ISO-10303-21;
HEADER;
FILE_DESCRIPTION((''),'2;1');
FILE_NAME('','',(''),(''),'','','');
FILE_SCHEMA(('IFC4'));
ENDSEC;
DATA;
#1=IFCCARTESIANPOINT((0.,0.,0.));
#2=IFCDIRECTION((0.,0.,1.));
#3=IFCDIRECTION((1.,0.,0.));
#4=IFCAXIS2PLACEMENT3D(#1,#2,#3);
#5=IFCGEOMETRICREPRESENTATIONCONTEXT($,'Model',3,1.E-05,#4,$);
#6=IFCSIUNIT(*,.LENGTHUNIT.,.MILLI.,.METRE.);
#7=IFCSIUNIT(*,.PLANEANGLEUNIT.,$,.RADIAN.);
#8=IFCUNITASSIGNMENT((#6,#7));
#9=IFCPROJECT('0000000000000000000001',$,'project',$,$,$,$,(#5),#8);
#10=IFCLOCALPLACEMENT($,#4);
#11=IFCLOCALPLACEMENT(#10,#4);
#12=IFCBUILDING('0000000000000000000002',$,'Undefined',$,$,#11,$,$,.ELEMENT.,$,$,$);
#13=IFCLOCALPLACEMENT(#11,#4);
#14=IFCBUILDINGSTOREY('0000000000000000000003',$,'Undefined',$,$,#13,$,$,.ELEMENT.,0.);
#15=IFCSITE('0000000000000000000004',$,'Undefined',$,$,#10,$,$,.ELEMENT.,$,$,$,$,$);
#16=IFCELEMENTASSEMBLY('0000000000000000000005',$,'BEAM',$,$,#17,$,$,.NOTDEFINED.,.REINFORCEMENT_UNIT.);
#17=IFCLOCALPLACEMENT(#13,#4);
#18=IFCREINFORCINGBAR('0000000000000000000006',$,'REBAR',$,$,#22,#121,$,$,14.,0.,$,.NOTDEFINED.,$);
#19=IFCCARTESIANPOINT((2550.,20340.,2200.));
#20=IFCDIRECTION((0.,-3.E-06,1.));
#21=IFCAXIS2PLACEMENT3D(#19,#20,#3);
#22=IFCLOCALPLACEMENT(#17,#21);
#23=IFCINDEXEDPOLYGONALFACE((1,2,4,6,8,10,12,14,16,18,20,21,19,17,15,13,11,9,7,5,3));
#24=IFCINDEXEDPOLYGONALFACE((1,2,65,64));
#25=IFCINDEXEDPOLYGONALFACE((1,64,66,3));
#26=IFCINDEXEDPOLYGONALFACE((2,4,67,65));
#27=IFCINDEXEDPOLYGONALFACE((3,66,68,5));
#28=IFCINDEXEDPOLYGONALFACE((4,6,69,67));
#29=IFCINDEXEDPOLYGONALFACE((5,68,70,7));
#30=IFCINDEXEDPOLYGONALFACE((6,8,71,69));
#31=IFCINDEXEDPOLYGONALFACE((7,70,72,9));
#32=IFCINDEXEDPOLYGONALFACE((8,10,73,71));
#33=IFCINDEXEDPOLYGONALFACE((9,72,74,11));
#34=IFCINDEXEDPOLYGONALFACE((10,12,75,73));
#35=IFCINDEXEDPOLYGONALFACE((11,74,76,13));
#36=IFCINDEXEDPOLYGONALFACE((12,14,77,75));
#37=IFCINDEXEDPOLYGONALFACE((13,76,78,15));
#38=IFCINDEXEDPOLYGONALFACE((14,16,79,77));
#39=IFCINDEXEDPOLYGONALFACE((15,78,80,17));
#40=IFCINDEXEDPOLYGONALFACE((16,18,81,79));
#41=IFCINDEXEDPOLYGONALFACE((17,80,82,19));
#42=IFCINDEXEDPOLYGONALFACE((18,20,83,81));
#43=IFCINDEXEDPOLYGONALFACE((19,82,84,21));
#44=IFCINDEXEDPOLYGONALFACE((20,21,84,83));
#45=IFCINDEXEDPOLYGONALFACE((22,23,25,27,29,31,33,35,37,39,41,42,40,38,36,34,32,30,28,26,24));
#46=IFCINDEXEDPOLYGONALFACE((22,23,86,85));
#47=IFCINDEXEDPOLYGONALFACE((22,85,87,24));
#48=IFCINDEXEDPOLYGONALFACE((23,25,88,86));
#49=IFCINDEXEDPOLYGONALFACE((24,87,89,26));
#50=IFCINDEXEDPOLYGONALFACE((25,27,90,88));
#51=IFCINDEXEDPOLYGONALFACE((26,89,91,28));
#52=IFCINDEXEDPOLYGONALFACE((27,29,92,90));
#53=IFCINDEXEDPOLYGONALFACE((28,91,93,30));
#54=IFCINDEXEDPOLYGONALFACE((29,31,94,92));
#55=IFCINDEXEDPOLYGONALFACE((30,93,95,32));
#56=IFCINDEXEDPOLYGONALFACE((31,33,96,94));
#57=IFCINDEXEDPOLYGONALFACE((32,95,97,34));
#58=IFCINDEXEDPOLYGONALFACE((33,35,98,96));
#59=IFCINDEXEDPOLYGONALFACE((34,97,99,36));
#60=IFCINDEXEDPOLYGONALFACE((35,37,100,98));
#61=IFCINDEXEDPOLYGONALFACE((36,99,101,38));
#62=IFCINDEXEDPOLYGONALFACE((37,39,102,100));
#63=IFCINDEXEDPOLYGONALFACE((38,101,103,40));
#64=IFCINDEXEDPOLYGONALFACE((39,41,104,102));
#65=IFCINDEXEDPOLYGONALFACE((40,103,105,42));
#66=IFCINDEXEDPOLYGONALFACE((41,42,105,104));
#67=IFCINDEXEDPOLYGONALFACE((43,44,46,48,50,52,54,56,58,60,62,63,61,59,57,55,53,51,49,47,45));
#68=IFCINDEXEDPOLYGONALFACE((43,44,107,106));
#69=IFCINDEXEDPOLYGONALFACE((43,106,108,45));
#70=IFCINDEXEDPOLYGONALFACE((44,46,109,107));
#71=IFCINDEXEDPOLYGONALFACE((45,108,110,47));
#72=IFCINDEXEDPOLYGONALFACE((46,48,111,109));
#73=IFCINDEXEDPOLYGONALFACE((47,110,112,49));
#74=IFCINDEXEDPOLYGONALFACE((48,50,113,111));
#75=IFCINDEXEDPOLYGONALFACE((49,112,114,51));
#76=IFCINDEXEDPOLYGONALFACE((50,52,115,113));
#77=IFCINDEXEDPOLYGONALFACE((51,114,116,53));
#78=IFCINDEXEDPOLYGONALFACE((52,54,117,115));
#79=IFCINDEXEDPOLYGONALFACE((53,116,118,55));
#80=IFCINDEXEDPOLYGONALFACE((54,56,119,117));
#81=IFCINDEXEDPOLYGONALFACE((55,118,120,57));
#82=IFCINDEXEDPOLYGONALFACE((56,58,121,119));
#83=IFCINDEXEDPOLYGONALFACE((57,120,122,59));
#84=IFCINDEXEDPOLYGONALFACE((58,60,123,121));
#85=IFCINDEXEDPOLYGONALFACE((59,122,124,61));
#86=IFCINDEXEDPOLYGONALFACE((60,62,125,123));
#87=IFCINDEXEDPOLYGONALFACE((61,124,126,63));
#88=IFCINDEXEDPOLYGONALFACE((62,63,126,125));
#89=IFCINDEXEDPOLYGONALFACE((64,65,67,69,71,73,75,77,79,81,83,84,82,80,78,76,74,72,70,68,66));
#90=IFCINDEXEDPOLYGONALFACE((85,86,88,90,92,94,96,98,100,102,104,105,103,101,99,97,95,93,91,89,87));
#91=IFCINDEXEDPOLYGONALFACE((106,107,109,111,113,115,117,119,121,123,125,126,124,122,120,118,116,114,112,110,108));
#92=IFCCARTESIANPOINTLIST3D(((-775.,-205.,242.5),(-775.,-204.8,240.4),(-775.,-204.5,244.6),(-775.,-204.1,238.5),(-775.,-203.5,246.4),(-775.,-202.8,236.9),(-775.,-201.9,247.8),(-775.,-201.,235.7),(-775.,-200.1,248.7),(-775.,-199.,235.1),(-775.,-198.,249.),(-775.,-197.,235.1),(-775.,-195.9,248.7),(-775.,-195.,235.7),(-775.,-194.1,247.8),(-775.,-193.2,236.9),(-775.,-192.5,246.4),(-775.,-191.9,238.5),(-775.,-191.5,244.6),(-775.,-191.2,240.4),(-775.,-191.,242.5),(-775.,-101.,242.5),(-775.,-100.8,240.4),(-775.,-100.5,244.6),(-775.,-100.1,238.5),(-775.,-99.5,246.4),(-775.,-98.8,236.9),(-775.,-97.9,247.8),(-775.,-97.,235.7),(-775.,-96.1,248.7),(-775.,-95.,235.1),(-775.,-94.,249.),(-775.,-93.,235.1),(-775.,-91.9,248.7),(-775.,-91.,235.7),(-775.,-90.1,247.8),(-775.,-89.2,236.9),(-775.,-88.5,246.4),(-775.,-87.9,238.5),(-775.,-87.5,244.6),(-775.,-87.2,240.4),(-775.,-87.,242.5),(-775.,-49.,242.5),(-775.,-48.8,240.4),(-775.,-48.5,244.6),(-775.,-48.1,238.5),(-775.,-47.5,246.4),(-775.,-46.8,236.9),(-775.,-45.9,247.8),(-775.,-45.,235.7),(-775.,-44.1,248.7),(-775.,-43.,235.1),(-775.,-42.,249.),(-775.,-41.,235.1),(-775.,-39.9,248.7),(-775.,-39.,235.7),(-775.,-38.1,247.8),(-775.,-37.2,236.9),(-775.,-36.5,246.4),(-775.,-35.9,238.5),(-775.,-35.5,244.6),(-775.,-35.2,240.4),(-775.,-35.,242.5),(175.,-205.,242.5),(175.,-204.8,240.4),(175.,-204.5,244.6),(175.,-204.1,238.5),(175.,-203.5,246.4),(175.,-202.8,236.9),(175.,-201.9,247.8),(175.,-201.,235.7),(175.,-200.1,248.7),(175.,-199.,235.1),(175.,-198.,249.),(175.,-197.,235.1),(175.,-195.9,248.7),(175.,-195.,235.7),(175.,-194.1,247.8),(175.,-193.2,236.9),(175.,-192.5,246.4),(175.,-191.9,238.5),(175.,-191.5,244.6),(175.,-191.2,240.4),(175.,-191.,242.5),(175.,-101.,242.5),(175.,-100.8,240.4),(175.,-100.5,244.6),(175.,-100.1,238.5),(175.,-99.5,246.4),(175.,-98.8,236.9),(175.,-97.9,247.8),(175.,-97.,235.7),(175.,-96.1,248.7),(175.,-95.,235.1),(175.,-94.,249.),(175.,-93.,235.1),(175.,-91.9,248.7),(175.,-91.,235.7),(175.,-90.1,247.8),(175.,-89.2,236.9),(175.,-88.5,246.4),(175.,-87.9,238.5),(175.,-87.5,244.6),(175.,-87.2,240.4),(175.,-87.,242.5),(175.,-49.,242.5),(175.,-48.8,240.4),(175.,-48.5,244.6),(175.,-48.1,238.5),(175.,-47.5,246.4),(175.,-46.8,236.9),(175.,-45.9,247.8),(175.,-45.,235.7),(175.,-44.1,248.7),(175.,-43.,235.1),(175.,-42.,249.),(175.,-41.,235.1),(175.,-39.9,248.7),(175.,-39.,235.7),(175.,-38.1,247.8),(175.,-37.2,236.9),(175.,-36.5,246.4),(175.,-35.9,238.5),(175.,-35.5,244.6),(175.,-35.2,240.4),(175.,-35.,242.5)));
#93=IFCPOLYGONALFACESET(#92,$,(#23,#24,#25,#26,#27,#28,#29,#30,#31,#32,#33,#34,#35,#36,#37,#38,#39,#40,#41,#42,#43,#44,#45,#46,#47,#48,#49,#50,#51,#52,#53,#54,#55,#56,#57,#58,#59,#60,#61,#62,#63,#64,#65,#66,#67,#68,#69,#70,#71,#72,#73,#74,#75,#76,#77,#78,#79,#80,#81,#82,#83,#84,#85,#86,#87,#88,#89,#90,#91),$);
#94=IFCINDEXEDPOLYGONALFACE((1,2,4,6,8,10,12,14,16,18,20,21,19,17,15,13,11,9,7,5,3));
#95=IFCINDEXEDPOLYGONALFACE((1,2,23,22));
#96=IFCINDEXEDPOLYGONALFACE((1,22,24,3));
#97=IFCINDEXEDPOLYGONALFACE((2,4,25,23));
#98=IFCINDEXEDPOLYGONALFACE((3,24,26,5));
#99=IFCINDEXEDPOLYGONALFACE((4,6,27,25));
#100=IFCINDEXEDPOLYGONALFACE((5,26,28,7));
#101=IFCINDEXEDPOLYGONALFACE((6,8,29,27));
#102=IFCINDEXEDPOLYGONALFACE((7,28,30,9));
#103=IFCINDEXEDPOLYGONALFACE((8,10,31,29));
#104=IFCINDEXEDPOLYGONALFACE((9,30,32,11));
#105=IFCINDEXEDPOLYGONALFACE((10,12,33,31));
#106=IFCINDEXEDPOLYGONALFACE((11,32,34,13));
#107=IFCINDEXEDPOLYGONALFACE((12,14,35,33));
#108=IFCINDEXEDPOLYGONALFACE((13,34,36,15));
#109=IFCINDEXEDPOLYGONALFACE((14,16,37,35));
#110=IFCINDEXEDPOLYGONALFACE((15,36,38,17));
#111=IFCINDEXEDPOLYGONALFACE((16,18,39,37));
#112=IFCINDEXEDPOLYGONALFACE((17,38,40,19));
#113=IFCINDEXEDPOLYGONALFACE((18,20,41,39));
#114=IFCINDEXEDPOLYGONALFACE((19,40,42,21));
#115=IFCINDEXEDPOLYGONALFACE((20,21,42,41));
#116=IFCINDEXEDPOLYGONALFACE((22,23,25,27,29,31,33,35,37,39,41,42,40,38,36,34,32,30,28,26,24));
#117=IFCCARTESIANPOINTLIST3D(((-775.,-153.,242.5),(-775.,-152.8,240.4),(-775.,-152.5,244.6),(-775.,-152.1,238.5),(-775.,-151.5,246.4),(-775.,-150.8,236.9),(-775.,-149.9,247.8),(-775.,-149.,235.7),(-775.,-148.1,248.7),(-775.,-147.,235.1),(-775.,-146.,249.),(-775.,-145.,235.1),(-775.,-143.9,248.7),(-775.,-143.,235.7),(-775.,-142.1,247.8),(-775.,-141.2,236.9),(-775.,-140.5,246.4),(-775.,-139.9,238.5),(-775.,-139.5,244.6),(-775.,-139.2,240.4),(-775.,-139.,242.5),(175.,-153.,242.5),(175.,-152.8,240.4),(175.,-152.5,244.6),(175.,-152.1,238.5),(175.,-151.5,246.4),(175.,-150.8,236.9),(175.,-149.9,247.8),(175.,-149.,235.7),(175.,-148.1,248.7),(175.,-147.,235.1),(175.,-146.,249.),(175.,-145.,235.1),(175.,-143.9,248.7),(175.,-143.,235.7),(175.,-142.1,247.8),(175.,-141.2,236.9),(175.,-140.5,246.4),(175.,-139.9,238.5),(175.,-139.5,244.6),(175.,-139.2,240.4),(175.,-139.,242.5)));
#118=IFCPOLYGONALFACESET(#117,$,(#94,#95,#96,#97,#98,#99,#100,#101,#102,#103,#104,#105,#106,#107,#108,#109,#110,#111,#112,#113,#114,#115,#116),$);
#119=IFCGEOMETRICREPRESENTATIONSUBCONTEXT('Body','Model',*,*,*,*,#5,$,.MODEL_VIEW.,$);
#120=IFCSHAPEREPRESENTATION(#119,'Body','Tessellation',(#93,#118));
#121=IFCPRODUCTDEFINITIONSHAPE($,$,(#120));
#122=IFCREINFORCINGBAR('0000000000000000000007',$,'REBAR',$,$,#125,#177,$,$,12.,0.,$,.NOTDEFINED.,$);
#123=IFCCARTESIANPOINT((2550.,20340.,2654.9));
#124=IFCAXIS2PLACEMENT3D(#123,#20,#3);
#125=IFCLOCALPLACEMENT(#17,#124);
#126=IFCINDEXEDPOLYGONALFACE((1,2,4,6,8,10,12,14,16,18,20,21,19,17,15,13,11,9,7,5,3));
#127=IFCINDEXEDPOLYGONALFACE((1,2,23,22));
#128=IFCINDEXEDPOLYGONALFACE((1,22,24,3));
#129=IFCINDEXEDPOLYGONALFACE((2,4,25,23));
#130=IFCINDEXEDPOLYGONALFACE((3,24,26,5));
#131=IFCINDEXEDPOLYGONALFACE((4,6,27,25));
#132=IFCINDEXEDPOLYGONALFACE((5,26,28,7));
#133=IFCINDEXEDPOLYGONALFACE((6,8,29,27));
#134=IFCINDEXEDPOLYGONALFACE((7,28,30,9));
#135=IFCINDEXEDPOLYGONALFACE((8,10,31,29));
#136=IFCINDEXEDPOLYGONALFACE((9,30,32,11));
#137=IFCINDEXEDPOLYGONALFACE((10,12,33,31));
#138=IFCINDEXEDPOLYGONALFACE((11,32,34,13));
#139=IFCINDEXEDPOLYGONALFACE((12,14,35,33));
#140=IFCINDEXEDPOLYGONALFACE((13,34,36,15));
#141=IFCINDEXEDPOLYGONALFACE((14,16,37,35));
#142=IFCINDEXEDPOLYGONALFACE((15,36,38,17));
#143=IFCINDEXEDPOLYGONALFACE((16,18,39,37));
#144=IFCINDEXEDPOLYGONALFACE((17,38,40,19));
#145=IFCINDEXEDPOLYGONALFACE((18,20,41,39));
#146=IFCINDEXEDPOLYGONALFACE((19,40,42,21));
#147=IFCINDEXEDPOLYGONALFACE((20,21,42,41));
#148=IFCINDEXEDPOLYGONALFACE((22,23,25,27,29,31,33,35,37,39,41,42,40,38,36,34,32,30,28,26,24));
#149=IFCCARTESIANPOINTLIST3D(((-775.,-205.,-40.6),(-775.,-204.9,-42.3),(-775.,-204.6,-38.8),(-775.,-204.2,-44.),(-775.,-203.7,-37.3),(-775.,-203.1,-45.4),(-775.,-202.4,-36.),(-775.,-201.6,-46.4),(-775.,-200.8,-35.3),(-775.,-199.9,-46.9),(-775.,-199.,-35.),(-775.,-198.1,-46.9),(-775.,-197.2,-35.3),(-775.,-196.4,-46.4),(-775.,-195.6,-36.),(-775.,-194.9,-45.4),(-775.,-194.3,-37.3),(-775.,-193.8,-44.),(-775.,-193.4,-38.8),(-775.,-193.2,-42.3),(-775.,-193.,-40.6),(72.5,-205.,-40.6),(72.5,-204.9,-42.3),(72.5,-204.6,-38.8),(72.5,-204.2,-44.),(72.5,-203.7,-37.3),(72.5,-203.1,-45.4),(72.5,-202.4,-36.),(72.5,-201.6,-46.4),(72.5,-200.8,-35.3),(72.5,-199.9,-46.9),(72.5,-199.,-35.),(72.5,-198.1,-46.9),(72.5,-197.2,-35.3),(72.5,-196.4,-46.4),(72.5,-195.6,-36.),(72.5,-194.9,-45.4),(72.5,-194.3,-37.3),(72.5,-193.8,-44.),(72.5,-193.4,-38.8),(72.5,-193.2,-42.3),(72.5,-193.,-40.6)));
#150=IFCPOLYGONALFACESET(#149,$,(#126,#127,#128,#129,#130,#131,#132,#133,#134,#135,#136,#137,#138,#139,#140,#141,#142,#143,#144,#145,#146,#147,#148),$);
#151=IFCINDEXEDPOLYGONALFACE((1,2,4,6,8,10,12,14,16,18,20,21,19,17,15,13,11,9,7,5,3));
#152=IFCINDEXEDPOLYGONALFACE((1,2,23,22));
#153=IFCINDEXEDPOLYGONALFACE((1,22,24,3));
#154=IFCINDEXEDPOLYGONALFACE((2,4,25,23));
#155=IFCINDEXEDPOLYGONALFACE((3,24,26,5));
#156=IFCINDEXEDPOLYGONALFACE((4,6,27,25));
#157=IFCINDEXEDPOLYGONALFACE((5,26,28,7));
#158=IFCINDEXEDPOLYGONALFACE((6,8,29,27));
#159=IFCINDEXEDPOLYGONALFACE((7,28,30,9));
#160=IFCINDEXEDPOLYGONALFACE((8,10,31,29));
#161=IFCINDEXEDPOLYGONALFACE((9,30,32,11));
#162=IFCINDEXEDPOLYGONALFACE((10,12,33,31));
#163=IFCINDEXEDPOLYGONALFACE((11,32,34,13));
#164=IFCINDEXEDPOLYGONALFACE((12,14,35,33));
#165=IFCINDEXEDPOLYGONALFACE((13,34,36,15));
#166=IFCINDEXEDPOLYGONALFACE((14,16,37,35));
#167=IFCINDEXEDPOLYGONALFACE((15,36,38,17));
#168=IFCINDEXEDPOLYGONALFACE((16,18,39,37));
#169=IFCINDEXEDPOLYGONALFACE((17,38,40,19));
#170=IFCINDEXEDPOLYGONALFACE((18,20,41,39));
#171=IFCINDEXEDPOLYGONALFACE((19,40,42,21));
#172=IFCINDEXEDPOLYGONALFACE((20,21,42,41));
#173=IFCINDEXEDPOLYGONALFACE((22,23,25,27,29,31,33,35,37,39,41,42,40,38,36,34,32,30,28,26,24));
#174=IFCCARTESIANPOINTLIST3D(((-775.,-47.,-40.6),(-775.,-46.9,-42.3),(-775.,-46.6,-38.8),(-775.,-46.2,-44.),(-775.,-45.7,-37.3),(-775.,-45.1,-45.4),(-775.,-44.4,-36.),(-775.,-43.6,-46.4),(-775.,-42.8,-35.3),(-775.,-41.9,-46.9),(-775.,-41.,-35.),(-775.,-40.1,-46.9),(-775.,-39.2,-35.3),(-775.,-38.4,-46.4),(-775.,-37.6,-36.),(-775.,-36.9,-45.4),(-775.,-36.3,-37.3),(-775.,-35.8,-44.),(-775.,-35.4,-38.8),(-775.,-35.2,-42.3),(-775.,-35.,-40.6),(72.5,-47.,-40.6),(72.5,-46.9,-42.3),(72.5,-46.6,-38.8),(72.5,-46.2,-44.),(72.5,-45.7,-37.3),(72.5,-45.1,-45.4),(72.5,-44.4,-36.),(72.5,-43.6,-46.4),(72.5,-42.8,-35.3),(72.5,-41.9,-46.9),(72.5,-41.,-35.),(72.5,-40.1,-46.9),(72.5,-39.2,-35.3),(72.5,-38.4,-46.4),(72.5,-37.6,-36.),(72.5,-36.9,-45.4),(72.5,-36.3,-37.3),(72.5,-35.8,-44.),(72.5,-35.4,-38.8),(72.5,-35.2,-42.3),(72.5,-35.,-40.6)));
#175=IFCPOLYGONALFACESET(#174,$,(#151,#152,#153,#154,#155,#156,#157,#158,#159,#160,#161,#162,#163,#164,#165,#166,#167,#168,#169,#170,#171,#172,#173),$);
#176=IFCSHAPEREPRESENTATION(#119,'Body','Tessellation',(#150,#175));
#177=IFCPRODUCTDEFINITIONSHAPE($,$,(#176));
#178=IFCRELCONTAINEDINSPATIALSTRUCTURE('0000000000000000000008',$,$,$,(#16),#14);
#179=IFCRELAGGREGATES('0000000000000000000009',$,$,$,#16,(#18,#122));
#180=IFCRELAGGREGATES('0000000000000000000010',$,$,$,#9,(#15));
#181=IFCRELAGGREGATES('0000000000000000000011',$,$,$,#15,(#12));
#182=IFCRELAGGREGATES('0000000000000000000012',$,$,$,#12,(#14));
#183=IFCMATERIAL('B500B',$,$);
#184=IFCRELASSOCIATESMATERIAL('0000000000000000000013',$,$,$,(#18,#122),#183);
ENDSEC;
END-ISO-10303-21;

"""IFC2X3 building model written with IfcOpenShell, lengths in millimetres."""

from ifc_helpers import new_model, entity, si_unit, frame, origin_with_axes, place, context, subcontext, project, spatial, source, transform, mapped, material, element, aggregate, save


model = new_model("IFC2X3")

# Units and contexts
model_context = context("Model", 3, precision=1e-05, world=origin_with_axes())
body_context = subcontext(model_context, "Body", "Model", "MODEL_VIEW")
ifc_project = project(units=[si_unit("LENGTHUNIT", "METRE", prefix="MILLI"), si_unit("PLANEANGLEUNIT", "RADIAN")], contexts=[model_context])

# Site, building, storey
site_placement = place(None, origin_with_axes())
site = spatial("IfcSite", under=ifc_project, at=site_placement, Name="Undefined", CompositionType="ELEMENT")
building_placement = place(site_placement, origin_with_axes())
building = spatial("IfcBuilding", under=site, at=building_placement, Name="Undefined", CompositionType="ELEMENT")
storey_placement = place(building_placement, origin_with_axes())
storey = spatial("IfcBuildingStorey", under=building, at=storey_placement, Name="Undefined", CompositionType="ELEMENT", Elevation=0.0)

# Element assembly
assembly_1_placement = place(storey_placement, origin_with_axes())
assembly_1 = element("IfcElementAssembly", 1, at=assembly_1_placement, inside=storey, Name="BEAM", AssemblyPlace="NOTDEFINED", PredefinedType="REINFORCEMENT_UNIT")

# Reinforcing bars
ifc_material_1 = material(Name="B500B")
shared_shape_1 = source(origin_with_axes(), body_context, "Body", "AdvancedSweptSolid", [
    entity("IfcSweptDiskSolid", entity("IfcTrimmedCurve", entity("IfcLine", entity("IfcCartesianPoint", [0.0, 0.0, 0.0]), entity("IfcVector", entity("IfcDirection", [1.0, 0.0, 0.0]), 1.0)), [entity("IfcParameterValue", 0.0)], [entity("IfcParameterValue", 949.999047)], True, "PARAMETER"), 7.0, None, 0.0, 950.0),
])
shared_shape_2 = source(origin_with_axes(), body_context, "Body", "AdvancedSweptSolid", [
    entity("IfcSweptDiskSolid", entity("IfcTrimmedCurve", entity("IfcLine", entity("IfcCartesianPoint", [0.0, 0.0, 0.0]), entity("IfcVector", entity("IfcDirection", [1.0, 0.0, 0.0]), 1.0)), [entity("IfcParameterValue", 0.0)], [entity("IfcParameterValue", 949.999047)], True, "PARAMETER"), 7.0, None, 0.0, 950.0),
])
shared_shape_3 = source(origin_with_axes(), body_context, "Body", "AdvancedSweptSolid", [
    entity("IfcSweptDiskSolid", entity("IfcTrimmedCurve", entity("IfcLine", entity("IfcCartesianPoint", [0.0, 0.0, 0.0]), entity("IfcVector", entity("IfcDirection", [1.0, 0.0, 0.0]), 1.0)), [entity("IfcParameterValue", 0.0)], [entity("IfcParameterValue", 949.999047)], True, "PARAMETER"), 7.0, None, 0.0, 950.0),
])
shared_shape_4 = source(origin_with_axes(), body_context, "Body", "AdvancedSweptSolid", [
    entity("IfcSweptDiskSolid", entity("IfcTrimmedCurve", entity("IfcLine", entity("IfcCartesianPoint", [0.0, 0.0, 0.0]), entity("IfcVector", entity("IfcDirection", [1.0, 0.0, 0.0]), 1.0)), [entity("IfcParameterValue", 0.0)], [entity("IfcParameterValue", 949.999047)], True, "PARAMETER"), 7.0, None, 0.0, 950.0),
])
reinforcing_bar_1_placement = place(assembly_1_placement, frame((2550.0, 20340.0, 2200.0), z_axis=(0.0, -0.000003, 1.0), x_axis=(1.0, 0.0, 0.0)))
reinforcing_bar_1 = element("IfcReinforcingBar", 2, at=reinforcing_bar_1_placement, material=ifc_material_1, Name="REBAR", BarRole="NOTDEFINED", CrossSectionArea=0.0, NominalDiameter=14.0, context=body_context, shape_type="MappedRepresentation", body=[
    mapped(shared_shape_1, transform((-775.0, -198.0, 242.0))),
    mapped(shared_shape_2, transform((-775.0, -146.0, 242.0))),
    mapped(shared_shape_3, transform((-775.0, -94.0, 242.0))),
    mapped(shared_shape_4, transform((-775.0, -42.0, 242.0))),
])
shared_shape_5 = source(origin_with_axes(), body_context, "Body", "AdvancedSweptSolid", [
    entity("IfcSweptDiskSolid", entity("IfcTrimmedCurve", entity("IfcLine", entity("IfcCartesianPoint", [0.0, 0.0, 0.0]), entity("IfcVector", entity("IfcDirection", [1.0, 0.0, 0.0]), 1.0)), [entity("IfcParameterValue", 0.0)], [entity("IfcParameterValue", 847.459613)], True, "PARAMETER"), 6.0, None, 0.0, 847.5),
])
shared_shape_6 = source(origin_with_axes(), body_context, "Body", "AdvancedSweptSolid", [
    entity("IfcSweptDiskSolid", entity("IfcTrimmedCurve", entity("IfcLine", entity("IfcCartesianPoint", [0.0, 0.0, 0.0]), entity("IfcVector", entity("IfcDirection", [1.0, 0.0, 0.0]), 1.0)), [entity("IfcParameterValue", 0.0)], [entity("IfcParameterValue", 847.459613)], True, "PARAMETER"), 6.0, None, 0.0, 847.5),
])
reinforcing_bar_2_placement = place(assembly_1_placement, frame((2550.0, 20340.0, 2654.9), z_axis=(0.0, -0.000003, 1.0), x_axis=(1.0, 0.0, 0.0)))
reinforcing_bar_2 = element("IfcReinforcingBar", 3, at=reinforcing_bar_2_placement, material=ifc_material_1, Name="REBAR", BarRole="NOTDEFINED", CrossSectionArea=0.0, NominalDiameter=12.0, context=body_context, shape_type="MappedRepresentation", body=[
    mapped(shared_shape_5, transform((-775.0, -199.0, -41.0))),
    mapped(shared_shape_6, transform((-775.0, -41.0, -41.0))),
])
aggregate(assembly_1, [reinforcing_bar_1, reinforcing_bar_2])

save(model, "model.ifc")
